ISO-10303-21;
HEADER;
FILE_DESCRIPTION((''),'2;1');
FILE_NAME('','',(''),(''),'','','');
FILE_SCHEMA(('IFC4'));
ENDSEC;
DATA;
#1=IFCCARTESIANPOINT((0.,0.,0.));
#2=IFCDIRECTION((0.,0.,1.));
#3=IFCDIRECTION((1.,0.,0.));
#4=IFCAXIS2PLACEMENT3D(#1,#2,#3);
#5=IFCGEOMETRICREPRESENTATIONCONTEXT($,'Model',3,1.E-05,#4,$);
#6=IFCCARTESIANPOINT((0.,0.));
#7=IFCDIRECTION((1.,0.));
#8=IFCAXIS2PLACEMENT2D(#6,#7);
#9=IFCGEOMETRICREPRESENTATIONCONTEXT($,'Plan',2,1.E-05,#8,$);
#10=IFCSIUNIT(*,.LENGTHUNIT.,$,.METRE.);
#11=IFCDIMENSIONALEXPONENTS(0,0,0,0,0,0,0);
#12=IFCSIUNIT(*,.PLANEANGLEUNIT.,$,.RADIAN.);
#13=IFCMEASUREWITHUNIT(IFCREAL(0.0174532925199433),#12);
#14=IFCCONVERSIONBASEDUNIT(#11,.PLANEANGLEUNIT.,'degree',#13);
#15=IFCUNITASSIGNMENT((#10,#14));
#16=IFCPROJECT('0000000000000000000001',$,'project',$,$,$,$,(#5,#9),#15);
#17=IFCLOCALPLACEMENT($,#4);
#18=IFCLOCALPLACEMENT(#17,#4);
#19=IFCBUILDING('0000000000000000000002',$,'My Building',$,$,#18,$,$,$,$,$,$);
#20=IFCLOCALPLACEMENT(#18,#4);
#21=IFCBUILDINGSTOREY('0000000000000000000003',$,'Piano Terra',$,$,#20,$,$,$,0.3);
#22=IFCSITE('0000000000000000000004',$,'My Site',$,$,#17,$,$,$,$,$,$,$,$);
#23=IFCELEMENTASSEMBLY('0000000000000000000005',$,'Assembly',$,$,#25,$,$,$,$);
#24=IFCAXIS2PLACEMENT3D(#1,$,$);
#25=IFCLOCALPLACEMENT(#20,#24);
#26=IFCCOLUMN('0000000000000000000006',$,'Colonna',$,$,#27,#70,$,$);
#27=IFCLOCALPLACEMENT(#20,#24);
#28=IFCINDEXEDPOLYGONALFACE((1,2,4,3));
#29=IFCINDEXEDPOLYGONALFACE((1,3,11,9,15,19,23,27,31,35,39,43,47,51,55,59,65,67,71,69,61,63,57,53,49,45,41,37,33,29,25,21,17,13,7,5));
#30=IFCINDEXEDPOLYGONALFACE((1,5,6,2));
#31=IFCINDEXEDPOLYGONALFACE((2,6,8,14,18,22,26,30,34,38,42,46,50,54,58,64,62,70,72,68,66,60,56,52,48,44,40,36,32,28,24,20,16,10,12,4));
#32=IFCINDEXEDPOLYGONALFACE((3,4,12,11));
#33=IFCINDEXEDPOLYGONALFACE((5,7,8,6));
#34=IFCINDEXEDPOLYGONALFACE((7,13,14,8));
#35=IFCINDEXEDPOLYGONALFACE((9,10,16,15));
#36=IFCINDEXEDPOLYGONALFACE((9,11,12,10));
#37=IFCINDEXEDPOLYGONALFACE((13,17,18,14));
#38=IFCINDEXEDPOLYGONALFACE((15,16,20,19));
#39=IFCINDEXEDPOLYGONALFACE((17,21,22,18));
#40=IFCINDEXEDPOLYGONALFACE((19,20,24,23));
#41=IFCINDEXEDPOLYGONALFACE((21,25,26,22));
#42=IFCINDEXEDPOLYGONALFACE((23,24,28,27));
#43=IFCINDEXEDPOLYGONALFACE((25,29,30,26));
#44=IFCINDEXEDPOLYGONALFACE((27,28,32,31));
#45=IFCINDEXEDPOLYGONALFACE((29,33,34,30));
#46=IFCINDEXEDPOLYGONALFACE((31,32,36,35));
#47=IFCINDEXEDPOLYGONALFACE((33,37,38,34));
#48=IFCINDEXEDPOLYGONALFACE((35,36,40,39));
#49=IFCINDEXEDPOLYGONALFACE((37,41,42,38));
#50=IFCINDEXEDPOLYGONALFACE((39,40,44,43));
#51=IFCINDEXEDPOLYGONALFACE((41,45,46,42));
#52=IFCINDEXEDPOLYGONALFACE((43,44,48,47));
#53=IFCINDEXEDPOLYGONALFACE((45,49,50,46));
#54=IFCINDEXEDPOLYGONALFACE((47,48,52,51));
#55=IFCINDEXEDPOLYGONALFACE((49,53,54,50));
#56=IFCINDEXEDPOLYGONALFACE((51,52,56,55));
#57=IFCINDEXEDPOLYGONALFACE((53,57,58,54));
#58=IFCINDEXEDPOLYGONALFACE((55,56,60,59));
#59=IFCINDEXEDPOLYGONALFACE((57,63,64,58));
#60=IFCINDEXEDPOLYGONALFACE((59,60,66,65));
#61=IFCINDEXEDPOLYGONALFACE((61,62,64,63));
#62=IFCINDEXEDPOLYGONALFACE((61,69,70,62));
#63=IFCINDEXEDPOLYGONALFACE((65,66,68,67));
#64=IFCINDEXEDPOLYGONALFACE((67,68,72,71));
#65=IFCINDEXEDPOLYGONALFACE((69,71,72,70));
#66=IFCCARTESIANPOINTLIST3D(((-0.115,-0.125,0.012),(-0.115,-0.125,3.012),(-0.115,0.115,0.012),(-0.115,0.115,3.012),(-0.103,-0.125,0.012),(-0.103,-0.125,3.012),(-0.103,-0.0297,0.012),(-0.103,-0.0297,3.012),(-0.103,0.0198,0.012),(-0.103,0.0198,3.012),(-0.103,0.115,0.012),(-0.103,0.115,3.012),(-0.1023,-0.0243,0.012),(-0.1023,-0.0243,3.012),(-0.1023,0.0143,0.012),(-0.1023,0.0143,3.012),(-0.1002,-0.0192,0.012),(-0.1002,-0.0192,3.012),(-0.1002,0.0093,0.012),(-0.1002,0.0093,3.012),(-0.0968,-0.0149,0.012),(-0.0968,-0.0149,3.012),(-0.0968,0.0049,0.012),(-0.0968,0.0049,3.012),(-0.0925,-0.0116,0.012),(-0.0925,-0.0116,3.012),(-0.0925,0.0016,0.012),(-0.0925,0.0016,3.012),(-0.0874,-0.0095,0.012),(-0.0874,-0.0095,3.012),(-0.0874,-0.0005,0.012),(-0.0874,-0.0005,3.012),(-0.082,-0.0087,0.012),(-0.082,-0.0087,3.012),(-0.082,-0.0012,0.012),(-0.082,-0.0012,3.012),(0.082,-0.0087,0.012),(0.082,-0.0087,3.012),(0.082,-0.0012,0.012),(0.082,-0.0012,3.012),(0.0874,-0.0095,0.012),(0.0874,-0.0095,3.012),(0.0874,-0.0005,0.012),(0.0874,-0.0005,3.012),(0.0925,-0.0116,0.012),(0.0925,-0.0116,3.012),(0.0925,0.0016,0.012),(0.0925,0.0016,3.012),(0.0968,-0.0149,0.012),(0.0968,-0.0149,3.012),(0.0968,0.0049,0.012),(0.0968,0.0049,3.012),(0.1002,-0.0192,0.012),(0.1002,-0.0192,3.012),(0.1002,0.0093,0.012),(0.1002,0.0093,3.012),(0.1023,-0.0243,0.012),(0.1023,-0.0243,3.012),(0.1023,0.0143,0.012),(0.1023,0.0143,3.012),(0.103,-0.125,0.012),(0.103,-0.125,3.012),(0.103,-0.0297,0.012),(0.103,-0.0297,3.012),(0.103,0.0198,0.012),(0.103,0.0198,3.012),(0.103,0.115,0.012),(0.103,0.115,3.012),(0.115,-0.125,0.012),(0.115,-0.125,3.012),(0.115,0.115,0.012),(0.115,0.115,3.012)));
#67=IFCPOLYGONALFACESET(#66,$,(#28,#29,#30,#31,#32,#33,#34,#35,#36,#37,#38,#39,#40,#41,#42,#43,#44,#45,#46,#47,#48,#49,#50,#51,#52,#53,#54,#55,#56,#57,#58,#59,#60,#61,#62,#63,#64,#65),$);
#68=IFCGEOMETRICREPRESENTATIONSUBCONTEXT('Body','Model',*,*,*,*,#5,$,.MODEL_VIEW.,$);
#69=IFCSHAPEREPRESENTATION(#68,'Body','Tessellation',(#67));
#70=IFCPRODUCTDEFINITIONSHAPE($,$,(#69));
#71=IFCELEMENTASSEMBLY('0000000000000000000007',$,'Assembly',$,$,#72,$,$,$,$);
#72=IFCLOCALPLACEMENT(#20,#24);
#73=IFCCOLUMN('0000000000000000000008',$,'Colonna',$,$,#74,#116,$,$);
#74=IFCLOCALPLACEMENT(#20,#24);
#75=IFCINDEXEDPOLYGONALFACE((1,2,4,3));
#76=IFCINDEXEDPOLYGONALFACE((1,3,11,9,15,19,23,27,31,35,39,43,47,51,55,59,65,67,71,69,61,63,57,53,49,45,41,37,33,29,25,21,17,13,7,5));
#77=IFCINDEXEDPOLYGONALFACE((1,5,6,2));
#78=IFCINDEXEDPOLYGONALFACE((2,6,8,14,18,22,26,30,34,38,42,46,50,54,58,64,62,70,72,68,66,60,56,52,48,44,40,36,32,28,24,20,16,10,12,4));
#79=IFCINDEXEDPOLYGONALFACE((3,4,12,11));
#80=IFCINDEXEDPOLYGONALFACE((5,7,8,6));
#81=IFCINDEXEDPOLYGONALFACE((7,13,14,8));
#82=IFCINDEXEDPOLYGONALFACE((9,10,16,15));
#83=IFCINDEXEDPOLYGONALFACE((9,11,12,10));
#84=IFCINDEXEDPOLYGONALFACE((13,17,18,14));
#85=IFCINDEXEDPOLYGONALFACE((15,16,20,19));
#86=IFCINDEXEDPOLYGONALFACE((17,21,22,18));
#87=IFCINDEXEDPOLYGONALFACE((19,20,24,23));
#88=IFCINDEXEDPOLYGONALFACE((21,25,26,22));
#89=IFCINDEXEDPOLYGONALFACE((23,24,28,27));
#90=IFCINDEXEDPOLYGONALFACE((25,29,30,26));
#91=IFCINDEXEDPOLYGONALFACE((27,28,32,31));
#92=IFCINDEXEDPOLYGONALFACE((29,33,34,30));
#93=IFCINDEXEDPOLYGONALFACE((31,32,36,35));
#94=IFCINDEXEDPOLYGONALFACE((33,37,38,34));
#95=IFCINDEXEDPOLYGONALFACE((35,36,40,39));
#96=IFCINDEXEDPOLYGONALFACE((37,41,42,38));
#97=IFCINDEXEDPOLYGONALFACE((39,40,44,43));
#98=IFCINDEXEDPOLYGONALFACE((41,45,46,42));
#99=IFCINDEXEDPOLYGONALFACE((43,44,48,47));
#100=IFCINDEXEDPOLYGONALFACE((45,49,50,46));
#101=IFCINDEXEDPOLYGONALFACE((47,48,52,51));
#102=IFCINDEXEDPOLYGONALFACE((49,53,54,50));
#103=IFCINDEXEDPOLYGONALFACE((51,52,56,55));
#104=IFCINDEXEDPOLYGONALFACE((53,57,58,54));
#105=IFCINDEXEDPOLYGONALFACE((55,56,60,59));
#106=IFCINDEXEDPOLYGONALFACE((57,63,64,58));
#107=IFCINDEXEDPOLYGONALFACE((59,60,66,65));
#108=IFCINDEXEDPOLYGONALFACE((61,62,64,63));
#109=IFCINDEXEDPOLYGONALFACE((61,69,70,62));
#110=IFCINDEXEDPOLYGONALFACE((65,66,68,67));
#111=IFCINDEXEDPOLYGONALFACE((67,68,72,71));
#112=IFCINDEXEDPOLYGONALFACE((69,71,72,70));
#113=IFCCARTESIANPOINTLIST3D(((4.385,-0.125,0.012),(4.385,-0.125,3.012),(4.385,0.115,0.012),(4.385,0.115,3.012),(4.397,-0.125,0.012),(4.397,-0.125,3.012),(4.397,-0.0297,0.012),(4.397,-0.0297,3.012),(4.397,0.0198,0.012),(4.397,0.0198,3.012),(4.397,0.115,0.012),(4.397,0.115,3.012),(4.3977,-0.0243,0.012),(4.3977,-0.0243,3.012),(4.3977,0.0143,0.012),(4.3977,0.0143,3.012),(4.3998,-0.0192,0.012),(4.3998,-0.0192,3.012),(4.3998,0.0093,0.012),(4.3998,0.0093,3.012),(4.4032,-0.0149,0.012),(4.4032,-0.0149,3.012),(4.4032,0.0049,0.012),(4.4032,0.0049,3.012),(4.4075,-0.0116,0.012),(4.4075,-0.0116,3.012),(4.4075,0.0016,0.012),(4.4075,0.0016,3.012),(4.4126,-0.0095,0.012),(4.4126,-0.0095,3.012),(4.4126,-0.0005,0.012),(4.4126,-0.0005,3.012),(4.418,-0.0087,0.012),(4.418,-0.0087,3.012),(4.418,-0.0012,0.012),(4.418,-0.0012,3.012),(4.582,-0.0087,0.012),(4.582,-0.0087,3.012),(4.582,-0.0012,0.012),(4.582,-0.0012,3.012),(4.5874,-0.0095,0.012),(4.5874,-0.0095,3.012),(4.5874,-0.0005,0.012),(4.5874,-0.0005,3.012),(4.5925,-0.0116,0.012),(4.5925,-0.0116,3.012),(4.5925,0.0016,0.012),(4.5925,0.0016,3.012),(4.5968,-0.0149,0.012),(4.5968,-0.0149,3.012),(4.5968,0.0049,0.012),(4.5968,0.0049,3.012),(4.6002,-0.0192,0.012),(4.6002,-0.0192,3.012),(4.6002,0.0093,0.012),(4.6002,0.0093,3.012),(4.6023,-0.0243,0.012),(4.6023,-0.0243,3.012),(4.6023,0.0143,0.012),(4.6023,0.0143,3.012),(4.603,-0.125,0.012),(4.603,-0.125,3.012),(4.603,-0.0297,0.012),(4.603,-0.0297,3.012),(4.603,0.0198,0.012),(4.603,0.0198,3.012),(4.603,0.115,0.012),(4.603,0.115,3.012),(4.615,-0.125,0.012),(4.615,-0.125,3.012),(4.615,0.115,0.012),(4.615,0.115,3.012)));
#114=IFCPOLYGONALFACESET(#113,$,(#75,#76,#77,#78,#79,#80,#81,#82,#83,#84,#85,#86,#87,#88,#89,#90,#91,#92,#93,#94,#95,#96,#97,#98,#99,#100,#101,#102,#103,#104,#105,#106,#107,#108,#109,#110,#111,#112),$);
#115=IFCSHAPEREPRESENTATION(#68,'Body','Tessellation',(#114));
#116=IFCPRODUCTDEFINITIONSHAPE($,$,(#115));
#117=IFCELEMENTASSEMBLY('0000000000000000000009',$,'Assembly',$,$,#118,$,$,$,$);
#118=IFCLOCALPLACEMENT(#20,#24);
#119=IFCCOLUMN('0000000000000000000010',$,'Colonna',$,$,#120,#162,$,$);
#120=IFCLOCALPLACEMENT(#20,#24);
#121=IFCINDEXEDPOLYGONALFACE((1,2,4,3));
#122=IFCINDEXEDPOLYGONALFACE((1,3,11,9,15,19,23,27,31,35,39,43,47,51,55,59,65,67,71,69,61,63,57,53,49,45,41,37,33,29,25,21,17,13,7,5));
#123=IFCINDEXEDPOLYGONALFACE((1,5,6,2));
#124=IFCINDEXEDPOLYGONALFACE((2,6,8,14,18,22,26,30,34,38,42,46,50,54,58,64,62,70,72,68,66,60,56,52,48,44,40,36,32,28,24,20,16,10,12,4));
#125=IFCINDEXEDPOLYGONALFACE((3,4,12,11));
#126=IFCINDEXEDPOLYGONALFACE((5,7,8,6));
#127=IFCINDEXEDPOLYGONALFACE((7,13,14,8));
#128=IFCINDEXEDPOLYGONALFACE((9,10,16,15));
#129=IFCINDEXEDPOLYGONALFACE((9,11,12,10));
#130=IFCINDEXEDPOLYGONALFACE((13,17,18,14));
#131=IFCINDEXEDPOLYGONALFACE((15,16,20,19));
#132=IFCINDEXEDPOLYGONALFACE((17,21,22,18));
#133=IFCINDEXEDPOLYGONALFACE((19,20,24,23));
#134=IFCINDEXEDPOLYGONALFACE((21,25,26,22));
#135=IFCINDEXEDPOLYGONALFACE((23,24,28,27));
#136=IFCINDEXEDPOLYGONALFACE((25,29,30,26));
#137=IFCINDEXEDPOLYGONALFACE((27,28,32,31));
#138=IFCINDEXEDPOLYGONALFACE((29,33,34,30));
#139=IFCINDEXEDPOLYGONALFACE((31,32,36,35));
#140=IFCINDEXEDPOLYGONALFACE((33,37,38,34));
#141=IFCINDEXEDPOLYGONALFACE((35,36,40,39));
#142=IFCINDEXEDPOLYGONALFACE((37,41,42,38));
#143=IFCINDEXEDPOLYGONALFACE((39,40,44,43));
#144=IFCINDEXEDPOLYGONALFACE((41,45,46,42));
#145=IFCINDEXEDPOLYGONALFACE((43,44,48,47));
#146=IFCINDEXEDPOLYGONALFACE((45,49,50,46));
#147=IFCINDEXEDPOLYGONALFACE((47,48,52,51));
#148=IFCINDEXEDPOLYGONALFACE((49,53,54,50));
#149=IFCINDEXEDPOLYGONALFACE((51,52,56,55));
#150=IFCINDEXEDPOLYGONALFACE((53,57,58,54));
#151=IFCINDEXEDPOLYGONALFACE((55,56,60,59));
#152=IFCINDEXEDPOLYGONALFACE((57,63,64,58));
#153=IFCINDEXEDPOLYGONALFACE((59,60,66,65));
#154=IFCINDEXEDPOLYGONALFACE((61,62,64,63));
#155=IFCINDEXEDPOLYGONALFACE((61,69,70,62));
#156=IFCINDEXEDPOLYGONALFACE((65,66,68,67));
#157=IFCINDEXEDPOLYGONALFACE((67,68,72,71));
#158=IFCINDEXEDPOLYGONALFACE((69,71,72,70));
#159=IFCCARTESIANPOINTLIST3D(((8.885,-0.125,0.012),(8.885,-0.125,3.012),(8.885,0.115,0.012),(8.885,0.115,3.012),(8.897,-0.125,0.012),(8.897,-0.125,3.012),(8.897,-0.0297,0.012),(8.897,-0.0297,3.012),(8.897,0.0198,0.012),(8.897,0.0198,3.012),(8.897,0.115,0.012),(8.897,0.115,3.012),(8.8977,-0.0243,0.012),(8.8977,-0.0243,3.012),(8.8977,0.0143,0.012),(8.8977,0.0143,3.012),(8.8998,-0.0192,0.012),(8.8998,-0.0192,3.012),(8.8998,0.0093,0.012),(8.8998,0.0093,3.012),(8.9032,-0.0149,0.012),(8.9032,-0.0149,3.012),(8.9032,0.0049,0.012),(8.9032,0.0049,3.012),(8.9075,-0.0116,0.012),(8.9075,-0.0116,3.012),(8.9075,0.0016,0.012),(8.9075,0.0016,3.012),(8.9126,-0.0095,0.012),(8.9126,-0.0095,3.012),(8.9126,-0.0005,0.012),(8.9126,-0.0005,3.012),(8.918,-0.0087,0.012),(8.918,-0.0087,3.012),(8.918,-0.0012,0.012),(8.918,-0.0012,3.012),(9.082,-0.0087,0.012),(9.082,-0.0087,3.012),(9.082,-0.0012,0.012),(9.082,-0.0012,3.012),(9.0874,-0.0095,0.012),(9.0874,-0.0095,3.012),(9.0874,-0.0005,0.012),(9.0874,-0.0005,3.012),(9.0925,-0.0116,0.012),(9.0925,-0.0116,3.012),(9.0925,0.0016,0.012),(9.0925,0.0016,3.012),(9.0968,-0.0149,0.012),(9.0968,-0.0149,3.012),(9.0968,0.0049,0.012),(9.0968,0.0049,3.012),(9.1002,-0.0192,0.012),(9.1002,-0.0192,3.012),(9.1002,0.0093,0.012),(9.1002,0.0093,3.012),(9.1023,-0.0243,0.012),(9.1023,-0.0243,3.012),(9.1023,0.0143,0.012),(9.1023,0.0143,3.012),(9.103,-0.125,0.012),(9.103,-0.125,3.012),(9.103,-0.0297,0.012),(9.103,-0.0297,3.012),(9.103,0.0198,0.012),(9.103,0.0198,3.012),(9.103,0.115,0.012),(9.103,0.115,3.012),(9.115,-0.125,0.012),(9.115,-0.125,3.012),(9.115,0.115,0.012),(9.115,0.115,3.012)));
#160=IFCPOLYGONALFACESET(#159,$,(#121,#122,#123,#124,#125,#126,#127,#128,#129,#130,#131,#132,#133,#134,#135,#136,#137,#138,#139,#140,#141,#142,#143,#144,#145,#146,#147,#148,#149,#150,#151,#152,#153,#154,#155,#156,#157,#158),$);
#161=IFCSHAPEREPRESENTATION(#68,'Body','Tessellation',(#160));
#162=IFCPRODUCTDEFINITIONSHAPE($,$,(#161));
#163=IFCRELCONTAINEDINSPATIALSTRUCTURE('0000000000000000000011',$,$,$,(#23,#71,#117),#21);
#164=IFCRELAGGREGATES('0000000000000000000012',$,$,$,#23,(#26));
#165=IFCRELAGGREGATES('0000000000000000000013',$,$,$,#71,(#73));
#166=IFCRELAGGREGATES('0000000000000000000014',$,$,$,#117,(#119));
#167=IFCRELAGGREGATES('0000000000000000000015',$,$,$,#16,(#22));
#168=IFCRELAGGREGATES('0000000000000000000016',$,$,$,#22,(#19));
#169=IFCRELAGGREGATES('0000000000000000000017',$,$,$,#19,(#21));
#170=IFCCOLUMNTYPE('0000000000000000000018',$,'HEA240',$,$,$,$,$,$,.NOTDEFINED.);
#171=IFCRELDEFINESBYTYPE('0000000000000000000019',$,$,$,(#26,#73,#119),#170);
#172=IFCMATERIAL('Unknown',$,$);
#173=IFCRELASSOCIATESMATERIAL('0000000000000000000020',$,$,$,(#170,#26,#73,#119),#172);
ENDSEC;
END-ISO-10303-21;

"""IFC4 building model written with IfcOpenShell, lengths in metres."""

from ifc_helpers import new_model, entity, si_unit, converted_unit, frame, origin_with_axes, origin_2d_with_axis, place, context, subcontext, project, spatial, i_section, extrude, material, material_profile, profile_set, profile_usage, type_object, element, aggregate, save


model = new_model("IFC4")

# Units and contexts
model_context = context("Model", 3, precision=1e-05, world=origin_with_axes())
plan_context = context("Plan", 2, precision=1e-05, world=origin_2d_with_axis())
body_context = subcontext(model_context, "Body", "Model", "MODEL_VIEW")
ifc_project = project(units=[si_unit("LENGTHUNIT", "METRE"), converted_unit("PLANEANGLEUNIT", "degree", entity("IfcReal", 0.0174532925199433), si_unit("PLANEANGLEUNIT", "RADIAN"), dimensions=[0, 0, 0, 0, 0, 0, 0])], contexts=[model_context, plan_context])

# Site, building, storey
site_placement = place(None, origin_with_axes())
site = spatial("IfcSite", under=ifc_project, at=site_placement, Name="My Site")
building_placement = place(site_placement, origin_with_axes())
building = spatial("IfcBuilding", under=site, at=building_placement, Name="My Building")
storey_placement = place(building_placement, origin_with_axes())
storey = spatial("IfcBuildingStorey", under=building, at=storey_placement, Name="Piano Terra", Elevation=0.3)

# Element assemblies, columns
assembly_1_placement = place(storey_placement, origin_with_axes())
assembly_1 = element("IfcElementAssembly", 1, at=assembly_1_placement, inside=storey, Name="Assembly")
ifc_material_1 = material(Name="Unknown")
ifc_material_profile = material_profile(ifc_material_1, i_section(OverallWidth=0.24, OverallDepth=0.23, WebThickness=0.0075, FlangeThickness=0.012, FilletRadius=0.021))
ifc_profile_set = profile_set([ifc_material_profile])
ifc_profile_usage_1 = profile_usage(ifc_profile_set)
column_type = type_object("IfcColumnType", Name="HEA240", PredefinedType="NOTDEFINED", material=ifc_profile_set)
column_1_placement = place(assembly_1_placement, frame((0.0, -0.005, 0.012), z_axis=(0.0, 0.0, 1.0), x_axis=(0.0, 1.0, 0.0)))
column_1 = element("IfcColumn", 2, at=column_1_placement, type_object=column_type, material=ifc_profile_usage_1, Name="Colonna", context=body_context, shape_type="SweptSolid", body=[
    extrude(i_section(OverallWidth=0.24, OverallDepth=0.23, WebThickness=0.0075, FlangeThickness=0.012, FilletRadius=0.021), origin_with_axes(), (0.0, 0.0, 1.0), 3.0),
])
assembly_2_placement = place(storey_placement, frame((4.5, 0.0, 0.0), z_axis=(0.0, 0.0, 1.0), x_axis=(1.0, 0.0, 0.0)))
assembly_2 = element("IfcElementAssembly", 3, at=assembly_2_placement, inside=storey, Name="Assembly")
ifc_profile_usage_2 = profile_usage(ifc_profile_set)
column_2_placement = place(assembly_2_placement, frame((0.0, -0.005, 0.012), z_axis=(0.0, 0.0, 1.0), x_axis=(0.0, 1.0, 0.0)))
column_2 = element("IfcColumn", 4, at=column_2_placement, type_object=column_type, material=ifc_profile_usage_2, Name="Colonna", context=body_context, shape_type="SweptSolid", body=[
    extrude(i_section(OverallWidth=0.24, OverallDepth=0.23, WebThickness=0.0075, FlangeThickness=0.012, FilletRadius=0.021), origin_with_axes(), (0.0, 0.0, 1.0), 3.0),
])
assembly_3_placement = place(storey_placement, frame((9.0, 0.0, 0.0), z_axis=(0.0, 0.0, 1.0), x_axis=(1.0, 0.0, 0.0)))
assembly_3 = element("IfcElementAssembly", 5, at=assembly_3_placement, inside=storey, Name="Assembly")
ifc_profile_usage_3 = profile_usage(ifc_profile_set)
column_3_placement = place(assembly_3_placement, frame((0.0, -0.005, 0.012), z_axis=(0.0, 0.0, 1.0), x_axis=(0.0, 1.0, 0.0)))
column_3 = element("IfcColumn", 6, at=column_3_placement, type_object=column_type, material=ifc_profile_usage_3, Name="Colonna", context=body_context, shape_type="SweptSolid", body=[
    extrude(i_section(OverallWidth=0.24, OverallDepth=0.23, WebThickness=0.0075, FlangeThickness=0.012, FilletRadius=0.021), origin_with_axes(), (0.0, 0.0, 1.0), 3.0),
])

aggregate(assembly_1, [column_1])
aggregate(assembly_2, [column_2])
aggregate(assembly_3, [column_3])

save(model, "model.ifc")
